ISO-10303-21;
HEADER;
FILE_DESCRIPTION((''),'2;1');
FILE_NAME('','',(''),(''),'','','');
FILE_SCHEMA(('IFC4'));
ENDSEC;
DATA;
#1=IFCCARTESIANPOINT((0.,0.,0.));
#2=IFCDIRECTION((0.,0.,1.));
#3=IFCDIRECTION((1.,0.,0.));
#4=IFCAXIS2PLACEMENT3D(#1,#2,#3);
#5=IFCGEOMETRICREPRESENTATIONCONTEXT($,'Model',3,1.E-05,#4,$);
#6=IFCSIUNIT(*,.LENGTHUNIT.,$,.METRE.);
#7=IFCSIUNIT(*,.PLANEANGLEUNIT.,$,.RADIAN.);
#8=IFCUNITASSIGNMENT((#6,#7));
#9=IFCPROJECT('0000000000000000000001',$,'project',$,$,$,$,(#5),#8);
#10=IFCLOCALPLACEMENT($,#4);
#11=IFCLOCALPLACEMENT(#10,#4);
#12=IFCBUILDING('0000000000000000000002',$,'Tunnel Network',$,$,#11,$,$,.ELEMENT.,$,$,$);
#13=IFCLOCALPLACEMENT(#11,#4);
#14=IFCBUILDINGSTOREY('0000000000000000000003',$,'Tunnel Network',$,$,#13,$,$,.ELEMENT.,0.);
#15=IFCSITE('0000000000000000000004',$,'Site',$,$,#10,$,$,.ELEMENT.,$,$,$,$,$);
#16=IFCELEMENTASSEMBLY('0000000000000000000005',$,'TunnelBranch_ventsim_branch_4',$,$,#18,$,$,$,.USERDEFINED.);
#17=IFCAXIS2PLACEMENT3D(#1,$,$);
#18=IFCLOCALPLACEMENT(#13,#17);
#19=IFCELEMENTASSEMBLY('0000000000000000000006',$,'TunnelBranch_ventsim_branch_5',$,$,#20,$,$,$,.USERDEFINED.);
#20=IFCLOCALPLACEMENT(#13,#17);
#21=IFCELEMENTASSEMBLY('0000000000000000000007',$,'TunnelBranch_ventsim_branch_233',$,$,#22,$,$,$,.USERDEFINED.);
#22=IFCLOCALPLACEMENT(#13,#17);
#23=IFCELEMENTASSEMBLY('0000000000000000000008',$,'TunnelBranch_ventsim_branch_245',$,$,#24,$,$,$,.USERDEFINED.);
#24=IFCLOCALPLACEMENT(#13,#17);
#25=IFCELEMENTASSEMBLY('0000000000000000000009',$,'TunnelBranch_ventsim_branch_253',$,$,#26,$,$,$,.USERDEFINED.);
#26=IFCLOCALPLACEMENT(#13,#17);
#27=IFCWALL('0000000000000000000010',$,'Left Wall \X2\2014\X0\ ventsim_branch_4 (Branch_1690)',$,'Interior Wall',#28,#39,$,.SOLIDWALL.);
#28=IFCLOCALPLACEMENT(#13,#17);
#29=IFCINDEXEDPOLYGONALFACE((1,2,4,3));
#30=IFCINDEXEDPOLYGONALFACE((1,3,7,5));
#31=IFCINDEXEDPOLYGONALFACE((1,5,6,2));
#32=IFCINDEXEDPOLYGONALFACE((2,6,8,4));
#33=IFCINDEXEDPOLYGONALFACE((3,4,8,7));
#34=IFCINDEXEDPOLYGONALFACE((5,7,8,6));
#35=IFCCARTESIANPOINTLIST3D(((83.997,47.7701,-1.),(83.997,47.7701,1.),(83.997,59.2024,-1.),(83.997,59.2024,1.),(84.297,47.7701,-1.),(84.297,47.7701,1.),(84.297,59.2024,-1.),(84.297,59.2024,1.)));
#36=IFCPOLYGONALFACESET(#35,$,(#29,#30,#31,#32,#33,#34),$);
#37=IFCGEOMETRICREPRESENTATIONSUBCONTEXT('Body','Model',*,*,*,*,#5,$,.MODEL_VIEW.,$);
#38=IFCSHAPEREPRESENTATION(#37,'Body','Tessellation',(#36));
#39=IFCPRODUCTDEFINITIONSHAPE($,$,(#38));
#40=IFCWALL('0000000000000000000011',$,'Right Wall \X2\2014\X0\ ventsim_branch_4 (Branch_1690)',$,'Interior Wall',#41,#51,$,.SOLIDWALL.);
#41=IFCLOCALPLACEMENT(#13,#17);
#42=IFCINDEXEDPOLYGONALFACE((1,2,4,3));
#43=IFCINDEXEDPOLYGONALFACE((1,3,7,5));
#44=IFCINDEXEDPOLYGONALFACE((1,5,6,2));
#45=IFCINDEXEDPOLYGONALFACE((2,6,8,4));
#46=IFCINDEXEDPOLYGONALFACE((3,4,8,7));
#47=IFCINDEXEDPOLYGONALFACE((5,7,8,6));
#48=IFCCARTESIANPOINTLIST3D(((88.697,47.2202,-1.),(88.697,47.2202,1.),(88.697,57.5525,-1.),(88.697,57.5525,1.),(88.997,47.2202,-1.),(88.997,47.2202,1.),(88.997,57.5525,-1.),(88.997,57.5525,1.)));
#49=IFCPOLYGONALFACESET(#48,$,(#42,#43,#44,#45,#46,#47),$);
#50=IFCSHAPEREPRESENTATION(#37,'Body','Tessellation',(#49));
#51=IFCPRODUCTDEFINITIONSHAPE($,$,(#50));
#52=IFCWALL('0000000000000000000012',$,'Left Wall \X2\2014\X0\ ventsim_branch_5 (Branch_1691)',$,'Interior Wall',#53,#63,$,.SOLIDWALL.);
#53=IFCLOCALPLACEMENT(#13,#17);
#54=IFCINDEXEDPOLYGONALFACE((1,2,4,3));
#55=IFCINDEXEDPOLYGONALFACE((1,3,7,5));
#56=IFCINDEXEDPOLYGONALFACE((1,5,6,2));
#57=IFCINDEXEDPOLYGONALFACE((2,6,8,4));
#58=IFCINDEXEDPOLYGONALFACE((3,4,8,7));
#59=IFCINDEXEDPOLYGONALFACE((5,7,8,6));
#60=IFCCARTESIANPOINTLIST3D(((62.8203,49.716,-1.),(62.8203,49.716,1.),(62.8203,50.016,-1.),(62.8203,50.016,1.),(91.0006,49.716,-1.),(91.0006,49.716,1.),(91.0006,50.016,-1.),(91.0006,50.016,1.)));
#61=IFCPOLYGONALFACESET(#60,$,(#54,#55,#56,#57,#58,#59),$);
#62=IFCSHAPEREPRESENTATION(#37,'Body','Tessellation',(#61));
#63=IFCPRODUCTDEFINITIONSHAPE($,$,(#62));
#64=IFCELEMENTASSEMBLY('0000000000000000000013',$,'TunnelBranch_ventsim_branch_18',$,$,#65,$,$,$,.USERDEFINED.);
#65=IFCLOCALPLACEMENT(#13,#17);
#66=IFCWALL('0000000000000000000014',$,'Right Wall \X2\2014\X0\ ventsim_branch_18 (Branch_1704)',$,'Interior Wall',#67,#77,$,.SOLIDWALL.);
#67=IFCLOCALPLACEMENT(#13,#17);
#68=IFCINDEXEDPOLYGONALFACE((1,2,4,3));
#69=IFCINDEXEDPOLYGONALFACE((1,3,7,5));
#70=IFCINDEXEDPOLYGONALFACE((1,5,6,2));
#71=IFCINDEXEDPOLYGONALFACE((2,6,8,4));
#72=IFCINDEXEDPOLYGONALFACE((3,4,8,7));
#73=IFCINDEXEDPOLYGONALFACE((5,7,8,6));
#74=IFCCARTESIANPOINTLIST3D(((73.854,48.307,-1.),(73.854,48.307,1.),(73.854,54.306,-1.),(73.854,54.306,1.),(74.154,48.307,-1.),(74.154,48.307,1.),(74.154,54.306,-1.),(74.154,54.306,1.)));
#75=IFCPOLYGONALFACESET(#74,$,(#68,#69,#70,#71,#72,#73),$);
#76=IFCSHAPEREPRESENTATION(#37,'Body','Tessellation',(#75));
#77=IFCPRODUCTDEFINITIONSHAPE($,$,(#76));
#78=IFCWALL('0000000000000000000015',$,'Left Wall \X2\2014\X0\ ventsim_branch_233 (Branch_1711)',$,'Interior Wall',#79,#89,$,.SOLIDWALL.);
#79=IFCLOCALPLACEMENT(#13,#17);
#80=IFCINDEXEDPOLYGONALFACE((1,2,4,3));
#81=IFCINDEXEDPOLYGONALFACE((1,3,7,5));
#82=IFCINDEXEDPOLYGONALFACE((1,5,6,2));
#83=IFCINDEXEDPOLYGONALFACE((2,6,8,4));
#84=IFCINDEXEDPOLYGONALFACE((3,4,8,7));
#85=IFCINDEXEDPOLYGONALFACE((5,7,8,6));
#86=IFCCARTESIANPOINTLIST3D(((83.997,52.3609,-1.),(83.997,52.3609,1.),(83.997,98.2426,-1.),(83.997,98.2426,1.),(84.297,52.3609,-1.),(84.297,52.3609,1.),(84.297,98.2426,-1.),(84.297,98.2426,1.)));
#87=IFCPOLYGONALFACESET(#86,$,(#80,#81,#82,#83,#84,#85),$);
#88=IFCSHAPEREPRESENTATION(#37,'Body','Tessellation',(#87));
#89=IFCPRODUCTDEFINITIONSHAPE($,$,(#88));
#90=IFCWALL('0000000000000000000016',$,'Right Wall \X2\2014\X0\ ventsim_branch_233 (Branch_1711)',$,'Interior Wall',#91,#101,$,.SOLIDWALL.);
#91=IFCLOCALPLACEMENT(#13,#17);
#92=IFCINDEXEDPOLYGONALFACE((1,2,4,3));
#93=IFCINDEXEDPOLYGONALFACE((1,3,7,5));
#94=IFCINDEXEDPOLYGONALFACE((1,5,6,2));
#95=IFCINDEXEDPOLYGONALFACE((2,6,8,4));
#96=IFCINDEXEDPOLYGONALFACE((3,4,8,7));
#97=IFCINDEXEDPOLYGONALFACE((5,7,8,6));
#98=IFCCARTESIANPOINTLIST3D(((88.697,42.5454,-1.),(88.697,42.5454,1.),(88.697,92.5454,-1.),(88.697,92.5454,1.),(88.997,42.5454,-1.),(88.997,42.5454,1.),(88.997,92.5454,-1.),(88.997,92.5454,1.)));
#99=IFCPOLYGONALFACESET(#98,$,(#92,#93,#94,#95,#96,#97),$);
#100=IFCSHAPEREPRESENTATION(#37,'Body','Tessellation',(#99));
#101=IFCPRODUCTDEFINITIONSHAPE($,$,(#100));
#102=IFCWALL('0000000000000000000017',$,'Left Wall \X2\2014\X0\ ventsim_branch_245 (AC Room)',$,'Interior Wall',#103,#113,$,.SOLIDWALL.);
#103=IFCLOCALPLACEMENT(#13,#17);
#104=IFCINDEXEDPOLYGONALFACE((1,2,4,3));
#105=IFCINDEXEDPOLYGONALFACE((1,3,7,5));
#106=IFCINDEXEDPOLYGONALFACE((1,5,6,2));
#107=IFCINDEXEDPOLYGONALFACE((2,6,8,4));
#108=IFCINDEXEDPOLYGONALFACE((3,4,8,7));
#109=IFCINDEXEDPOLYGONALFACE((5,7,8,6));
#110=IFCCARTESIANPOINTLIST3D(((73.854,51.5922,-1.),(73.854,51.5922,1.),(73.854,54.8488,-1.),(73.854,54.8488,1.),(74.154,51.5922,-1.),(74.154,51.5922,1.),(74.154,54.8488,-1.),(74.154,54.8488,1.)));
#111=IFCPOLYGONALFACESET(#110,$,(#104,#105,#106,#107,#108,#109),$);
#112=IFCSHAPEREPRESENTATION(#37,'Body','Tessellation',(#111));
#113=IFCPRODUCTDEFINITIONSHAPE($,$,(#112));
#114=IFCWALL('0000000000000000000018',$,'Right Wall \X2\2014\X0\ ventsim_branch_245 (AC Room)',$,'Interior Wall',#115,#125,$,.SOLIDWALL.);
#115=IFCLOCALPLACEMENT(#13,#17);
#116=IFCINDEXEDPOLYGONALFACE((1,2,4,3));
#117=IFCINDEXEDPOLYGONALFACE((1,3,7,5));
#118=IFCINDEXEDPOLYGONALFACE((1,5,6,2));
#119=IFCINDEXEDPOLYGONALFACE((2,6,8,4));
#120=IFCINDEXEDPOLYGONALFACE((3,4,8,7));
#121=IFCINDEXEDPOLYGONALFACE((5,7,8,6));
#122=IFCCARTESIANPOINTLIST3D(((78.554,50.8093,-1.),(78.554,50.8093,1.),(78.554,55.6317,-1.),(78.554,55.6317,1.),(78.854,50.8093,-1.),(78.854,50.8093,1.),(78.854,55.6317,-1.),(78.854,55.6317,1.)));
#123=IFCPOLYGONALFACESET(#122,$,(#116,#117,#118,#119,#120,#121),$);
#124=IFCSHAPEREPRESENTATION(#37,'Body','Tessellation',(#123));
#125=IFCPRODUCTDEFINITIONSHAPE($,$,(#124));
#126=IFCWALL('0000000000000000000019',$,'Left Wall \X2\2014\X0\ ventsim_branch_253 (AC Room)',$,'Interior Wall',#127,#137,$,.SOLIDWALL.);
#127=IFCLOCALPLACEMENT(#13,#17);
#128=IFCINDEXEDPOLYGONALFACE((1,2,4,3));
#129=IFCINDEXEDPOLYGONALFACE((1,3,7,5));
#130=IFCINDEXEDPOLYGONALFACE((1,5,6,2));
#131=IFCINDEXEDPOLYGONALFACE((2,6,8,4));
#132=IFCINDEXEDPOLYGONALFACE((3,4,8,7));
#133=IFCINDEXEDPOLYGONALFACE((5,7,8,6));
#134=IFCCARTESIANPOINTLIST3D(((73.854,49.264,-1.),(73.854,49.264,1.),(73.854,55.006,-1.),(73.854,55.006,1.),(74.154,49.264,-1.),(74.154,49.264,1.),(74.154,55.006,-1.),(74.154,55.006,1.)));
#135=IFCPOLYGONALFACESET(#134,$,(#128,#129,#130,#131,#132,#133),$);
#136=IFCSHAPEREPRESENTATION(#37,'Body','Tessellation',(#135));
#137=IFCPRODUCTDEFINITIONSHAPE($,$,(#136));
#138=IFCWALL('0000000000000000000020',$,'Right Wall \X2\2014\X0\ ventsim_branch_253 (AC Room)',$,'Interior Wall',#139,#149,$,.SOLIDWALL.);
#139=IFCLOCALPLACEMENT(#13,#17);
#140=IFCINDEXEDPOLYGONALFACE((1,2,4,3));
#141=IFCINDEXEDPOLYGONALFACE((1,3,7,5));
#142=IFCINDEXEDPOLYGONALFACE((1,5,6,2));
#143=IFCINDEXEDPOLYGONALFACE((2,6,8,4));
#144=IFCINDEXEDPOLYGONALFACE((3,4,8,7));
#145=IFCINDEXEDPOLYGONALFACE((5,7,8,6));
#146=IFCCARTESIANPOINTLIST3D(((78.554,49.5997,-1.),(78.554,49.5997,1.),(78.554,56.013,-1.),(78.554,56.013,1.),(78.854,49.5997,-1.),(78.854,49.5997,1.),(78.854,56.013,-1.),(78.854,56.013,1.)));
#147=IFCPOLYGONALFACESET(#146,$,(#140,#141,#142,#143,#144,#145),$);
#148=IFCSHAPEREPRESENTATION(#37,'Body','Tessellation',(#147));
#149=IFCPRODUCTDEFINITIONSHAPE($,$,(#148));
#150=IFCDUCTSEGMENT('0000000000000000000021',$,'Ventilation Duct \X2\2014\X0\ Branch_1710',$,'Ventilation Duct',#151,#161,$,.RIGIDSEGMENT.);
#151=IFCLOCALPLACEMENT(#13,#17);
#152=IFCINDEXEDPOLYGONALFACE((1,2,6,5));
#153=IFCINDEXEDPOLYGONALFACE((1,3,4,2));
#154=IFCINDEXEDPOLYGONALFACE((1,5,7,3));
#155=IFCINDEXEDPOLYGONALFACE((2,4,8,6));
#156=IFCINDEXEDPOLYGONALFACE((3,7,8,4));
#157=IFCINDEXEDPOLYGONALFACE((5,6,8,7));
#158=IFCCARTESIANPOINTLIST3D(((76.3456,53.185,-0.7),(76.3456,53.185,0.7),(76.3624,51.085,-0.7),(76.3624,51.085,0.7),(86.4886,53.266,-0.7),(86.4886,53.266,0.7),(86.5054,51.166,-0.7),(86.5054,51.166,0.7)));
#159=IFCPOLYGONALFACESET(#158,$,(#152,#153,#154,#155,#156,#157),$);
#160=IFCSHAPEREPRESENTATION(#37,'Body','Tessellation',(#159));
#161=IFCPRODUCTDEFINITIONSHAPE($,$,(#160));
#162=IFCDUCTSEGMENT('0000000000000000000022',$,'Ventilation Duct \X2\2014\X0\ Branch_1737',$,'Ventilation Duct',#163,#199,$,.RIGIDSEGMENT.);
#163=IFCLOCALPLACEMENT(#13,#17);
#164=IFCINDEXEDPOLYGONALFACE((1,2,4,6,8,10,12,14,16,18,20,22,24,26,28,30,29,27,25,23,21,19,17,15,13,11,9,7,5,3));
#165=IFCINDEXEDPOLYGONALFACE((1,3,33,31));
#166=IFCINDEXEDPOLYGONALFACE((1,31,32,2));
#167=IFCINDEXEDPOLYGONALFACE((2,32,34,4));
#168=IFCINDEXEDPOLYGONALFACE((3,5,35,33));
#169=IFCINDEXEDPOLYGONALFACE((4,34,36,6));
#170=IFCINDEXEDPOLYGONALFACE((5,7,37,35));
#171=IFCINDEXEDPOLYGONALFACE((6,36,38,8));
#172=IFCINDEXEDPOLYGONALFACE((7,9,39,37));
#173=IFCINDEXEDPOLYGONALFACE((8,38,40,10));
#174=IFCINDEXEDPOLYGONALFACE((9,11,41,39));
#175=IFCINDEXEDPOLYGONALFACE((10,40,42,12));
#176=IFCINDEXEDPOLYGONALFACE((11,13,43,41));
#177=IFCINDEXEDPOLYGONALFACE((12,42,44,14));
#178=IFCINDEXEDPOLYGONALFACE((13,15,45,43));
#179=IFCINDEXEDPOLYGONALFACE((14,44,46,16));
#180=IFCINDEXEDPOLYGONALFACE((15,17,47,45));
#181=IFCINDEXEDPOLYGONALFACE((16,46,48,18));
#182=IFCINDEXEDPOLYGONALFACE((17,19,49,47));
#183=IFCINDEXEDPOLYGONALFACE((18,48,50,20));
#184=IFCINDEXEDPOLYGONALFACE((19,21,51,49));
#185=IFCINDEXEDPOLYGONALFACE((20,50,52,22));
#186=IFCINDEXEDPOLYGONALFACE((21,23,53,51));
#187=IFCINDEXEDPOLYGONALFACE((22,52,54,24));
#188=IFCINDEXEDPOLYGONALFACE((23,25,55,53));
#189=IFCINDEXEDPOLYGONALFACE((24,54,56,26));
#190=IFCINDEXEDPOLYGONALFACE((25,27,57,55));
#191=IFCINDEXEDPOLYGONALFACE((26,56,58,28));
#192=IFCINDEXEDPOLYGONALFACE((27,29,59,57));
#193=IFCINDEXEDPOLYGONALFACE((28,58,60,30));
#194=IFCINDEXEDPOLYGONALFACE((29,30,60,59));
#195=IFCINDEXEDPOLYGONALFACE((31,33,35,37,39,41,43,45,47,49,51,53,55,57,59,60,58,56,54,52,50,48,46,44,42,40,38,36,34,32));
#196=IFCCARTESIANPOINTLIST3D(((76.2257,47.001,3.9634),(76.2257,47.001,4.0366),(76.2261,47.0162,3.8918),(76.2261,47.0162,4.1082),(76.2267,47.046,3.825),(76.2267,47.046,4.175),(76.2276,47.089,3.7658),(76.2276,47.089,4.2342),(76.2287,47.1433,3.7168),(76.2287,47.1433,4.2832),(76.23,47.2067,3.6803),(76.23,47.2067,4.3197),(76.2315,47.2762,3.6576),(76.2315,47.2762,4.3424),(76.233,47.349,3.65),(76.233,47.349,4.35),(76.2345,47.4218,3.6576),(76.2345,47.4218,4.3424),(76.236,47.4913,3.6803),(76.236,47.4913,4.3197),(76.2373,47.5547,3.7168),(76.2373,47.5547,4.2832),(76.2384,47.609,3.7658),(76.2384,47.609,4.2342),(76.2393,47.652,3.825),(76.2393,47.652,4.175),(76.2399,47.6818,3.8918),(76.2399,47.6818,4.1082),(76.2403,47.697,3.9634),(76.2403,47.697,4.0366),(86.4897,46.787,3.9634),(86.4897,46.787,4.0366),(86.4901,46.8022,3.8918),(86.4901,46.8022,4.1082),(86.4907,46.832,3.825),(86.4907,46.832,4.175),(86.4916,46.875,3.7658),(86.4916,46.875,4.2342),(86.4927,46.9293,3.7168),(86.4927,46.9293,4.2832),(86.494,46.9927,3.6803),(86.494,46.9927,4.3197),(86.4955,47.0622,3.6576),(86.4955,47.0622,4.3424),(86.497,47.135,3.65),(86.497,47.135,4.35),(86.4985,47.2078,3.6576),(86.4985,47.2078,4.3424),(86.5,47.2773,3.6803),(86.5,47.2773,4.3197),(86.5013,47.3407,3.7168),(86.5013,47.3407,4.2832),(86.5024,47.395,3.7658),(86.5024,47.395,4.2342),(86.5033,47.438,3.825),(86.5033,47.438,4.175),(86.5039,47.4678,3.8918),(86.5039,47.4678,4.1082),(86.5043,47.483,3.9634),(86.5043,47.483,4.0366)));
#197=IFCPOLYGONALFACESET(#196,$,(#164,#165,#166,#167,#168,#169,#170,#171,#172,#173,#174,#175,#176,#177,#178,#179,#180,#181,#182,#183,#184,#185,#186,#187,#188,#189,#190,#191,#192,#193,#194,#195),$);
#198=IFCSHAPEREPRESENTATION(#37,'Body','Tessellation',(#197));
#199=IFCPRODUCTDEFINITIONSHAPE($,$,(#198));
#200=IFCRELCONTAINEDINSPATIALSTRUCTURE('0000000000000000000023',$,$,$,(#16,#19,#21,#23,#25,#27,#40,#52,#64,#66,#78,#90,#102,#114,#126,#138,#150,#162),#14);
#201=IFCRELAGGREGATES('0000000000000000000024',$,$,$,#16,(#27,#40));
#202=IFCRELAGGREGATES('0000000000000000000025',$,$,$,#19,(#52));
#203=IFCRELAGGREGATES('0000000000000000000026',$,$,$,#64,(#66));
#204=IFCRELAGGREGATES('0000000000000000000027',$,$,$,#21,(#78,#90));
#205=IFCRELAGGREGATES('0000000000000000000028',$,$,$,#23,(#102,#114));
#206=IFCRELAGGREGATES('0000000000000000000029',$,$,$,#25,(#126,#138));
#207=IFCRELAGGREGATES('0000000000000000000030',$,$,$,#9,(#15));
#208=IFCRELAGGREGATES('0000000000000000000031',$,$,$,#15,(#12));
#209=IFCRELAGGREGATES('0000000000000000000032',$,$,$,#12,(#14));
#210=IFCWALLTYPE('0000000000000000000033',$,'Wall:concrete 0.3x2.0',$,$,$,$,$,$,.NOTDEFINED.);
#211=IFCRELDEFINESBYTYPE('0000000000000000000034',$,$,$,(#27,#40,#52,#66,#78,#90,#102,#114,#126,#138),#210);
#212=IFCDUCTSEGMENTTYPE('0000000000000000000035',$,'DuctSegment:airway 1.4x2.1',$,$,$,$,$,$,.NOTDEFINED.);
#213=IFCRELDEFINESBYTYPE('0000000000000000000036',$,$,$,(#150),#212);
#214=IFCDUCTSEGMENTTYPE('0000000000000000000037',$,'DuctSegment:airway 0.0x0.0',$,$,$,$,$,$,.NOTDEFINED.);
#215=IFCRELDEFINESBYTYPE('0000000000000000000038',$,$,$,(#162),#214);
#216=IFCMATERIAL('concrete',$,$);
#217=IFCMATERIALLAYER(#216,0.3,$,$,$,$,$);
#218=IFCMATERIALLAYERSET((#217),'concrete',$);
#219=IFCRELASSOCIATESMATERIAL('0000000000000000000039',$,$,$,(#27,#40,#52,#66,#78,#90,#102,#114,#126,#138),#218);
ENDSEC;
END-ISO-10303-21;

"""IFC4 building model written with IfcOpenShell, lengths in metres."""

from ifc_helpers import new_model, si_unit, frame, origin_with_axes, origin_2d_with_axis, place, context, subcontext, project, spatial, rectangle, circle, extrude, material, layer, layer_set, layer_usage, type_object, element, aggregate, save


model = new_model("IFC4")

# Units and contexts
model_context = context("Model", 3, precision=1e-05, world=origin_with_axes())
body_context = subcontext(model_context, "Body", "Model", "MODEL_VIEW")
ifc_project = project(units=[si_unit("LENGTHUNIT", "METRE"), si_unit("PLANEANGLEUNIT", "RADIAN")], contexts=[model_context])

# Site, building, storey
site_placement = place(None, origin_with_axes())
site = spatial("IfcSite", under=ifc_project, at=site_placement, Name="Site", CompositionType="ELEMENT")
building_placement = place(site_placement, origin_with_axes())
building = spatial("IfcBuilding", under=site, at=building_placement, Name="Tunnel Network", CompositionType="ELEMENT")
storey_placement = place(building_placement, origin_with_axes())
storey = spatial("IfcBuildingStorey", under=building, at=storey_placement, Name="Tunnel Network", CompositionType="ELEMENT", Elevation=0.0)

# Element assemblies
assembly_1_placement = place(storey_placement, frame((84.147, 47.7701, 0.0), z_axis=(0.0, 1.0, 0.0), x_axis=(1.0, 0.0, 0.0)))
assembly_1 = element("IfcElementAssembly", 1, at=assembly_1_placement, inside=storey, Name="TunnelBranch_ventsim_branch_4", PredefinedType="USERDEFINED")
ifc_material_1 = material(Name="concrete")
ifc_layer_1 = layer(ifc_material_1, 0.3)
ifc_layer_set_1 = layer_set([ifc_layer_1], Name="concrete")
assembly_2_placement = place(storey_placement, frame((91.0006, 49.866, 0.0), z_axis=(-1.0, 0.0, 0.0), x_axis=(0.0, 1.0, 0.0)))
assembly_2 = element("IfcElementAssembly", 2, at=assembly_2_placement, inside=storey, Name="TunnelBranch_ventsim_branch_5", PredefinedType="USERDEFINED")
assembly_3_placement = place(storey_placement, frame((84.147, 52.3609, 0.0), z_axis=(0.0, 1.0, 0.0), x_axis=(1.0, 0.0, 0.0)))
assembly_3 = element("IfcElementAssembly", 3, at=assembly_3_placement, inside=storey, Name="TunnelBranch_ventsim_branch_233", PredefinedType="USERDEFINED")
assembly_4_placement = place(storey_placement, frame((74.004, 51.5922, 0.0), z_axis=(0.0, 1.0, 0.0), x_axis=(1.0, 0.0, 0.0)))
assembly_4 = element("IfcElementAssembly", 4, at=assembly_4_placement, inside=storey, Name="TunnelBranch_ventsim_branch_245", PredefinedType="USERDEFINED")
assembly_5_placement = place(storey_placement, frame((74.004, 49.264, 0.0), z_axis=(0.0, 1.0, 0.0), x_axis=(1.0, 0.0, 0.0)))
assembly_5 = element("IfcElementAssembly", 5, at=assembly_5_placement, inside=storey, Name="TunnelBranch_ventsim_branch_253", PredefinedType="USERDEFINED")

# Walls
ifc_layer_usage_1 = layer_usage(ifc_layer_set_1, "AXIS2", "POSITIVE", 0.0)
wall_type_1 = type_object("IfcWallType", Name="Wall:concrete 0.3x2.0")
wall_1_placement = place(storey_placement, frame((84.147, 47.7701, 0.0), z_axis=(0.0, 1.0, 0.0), x_axis=(1.0, 0.0, 0.0)))
wall_1 = element("IfcWall", 6, at=wall_1_placement, inside=storey, type_object=wall_type_1, material=ifc_layer_usage_1, Name="Left Wall — ventsim_branch_4 (Branch_1690)", ObjectType="Interior Wall", PredefinedType="SOLIDWALL", context=body_context, shape_type="SweptSolid", body=[
    extrude(rectangle(XDim=0.3, YDim=2.0, at=origin_2d_with_axis()), origin_with_axes(), (0.0, 0.0, 1.0), 11.4323),
])
ifc_layer_usage_2 = layer_usage(ifc_layer_set_1, "AXIS2", "POSITIVE", 0.0)
wall_2_placement = place(storey_placement, frame((88.847, 47.2202, 0.0), z_axis=(0.0, 1.0, 0.0), x_axis=(1.0, 0.0, 0.0)))
wall_2 = element("IfcWall", 7, at=wall_2_placement, inside=storey, type_object=wall_type_1, material=ifc_layer_usage_2, Name="Right Wall — ventsim_branch_4 (Branch_1690)", ObjectType="Interior Wall", PredefinedType="SOLIDWALL", context=body_context, shape_type="SweptSolid", body=[
    extrude(rectangle(XDim=0.3, YDim=2.0, at=origin_2d_with_axis()), origin_with_axes(), (0.0, 0.0, 1.0), 10.3323),
])
aggregate(assembly_1, [wall_1, wall_2])
ifc_layer_usage_3 = layer_usage(ifc_layer_set_1, "AXIS2", "POSITIVE", 0.0)
wall_3_placement = place(storey_placement, frame((91.0006, 49.866, 0.0), z_axis=(-1.0, 0.0, 0.0), x_axis=(0.0, 1.0, 0.0)))
wall_3 = element("IfcWall", 8, at=wall_3_placement, inside=storey, type_object=wall_type_1, material=ifc_layer_usage_3, Name="Left Wall — ventsim_branch_5 (Branch_1691)", ObjectType="Interior Wall", PredefinedType="SOLIDWALL", context=body_context, shape_type="SweptSolid", body=[
    extrude(rectangle(XDim=0.3, YDim=2.0, at=origin_2d_with_axis()), origin_with_axes(), (0.0, 0.0, 1.0), 28.1803),
])
aggregate(assembly_2, [wall_3])

# Element assembly, wall
assembly_6_placement = place(storey_placement, frame((78.704, 54.306, 0.0), z_axis=(0.0, -1.0, 0.0), x_axis=(-1.0, 0.0, 0.0)))
assembly_6 = element("IfcElementAssembly", 9, at=assembly_6_placement, inside=storey, Name="TunnelBranch_ventsim_branch_18", PredefinedType="USERDEFINED")
ifc_layer_usage_4 = layer_usage(ifc_layer_set_1, "AXIS2", "POSITIVE", 0.0)
wall_4_placement = place(storey_placement, frame((74.004, 54.306, 0.0), z_axis=(0.0, -1.0, 0.0), x_axis=(-1.0, 0.0, 0.0)))
wall_4 = element("IfcWall", 10, at=wall_4_placement, inside=storey, type_object=wall_type_1, material=ifc_layer_usage_4, Name="Right Wall — ventsim_branch_18 (Branch_1704)", ObjectType="Interior Wall", PredefinedType="SOLIDWALL", context=body_context, shape_type="SweptSolid", body=[
    extrude(rectangle(XDim=0.3, YDim=2.0, at=origin_2d_with_axis()), origin_with_axes(), (0.0, 0.0, 1.0), 5.999),
])
aggregate(assembly_6, [wall_4])

# Walls
ifc_layer_usage_5 = layer_usage(ifc_layer_set_1, "AXIS2", "POSITIVE", 0.0)
wall_5_placement = place(storey_placement, frame((84.147, 52.3609, 0.0), z_axis=(0.0, 1.0, 0.0), x_axis=(1.0, 0.0, 0.0)))
wall_5 = element("IfcWall", 11, at=wall_5_placement, inside=storey, type_object=wall_type_1, material=ifc_layer_usage_5, Name="Left Wall — ventsim_branch_233 (Branch_1711)", ObjectType="Interior Wall", PredefinedType="SOLIDWALL", context=body_context, shape_type="SweptSolid", body=[
    extrude(rectangle(XDim=0.3, YDim=2.0, at=origin_2d_with_axis()), origin_with_axes(), (0.0, 0.0, 1.0), 45.8817),
])
ifc_layer_usage_6 = layer_usage(ifc_layer_set_1, "AXIS2", "POSITIVE", 0.0)
wall_6_placement = place(storey_placement, frame((88.847, 42.5454, 0.0), z_axis=(0.0, 1.0, 0.0), x_axis=(1.0, 0.0, 0.0)))
wall_6 = element("IfcWall", 12, at=wall_6_placement, inside=storey, type_object=wall_type_1, material=ifc_layer_usage_6, Name="Right Wall — ventsim_branch_233 (Branch_1711)", ObjectType="Interior Wall", PredefinedType="SOLIDWALL", context=body_context, shape_type="SweptSolid", body=[
    extrude(rectangle(XDim=0.3, YDim=2.0, at=origin_2d_with_axis()), origin_with_axes(), (0.0, 0.0, 1.0), 50.0),
])
aggregate(assembly_3, [wall_5, wall_6])
ifc_layer_usage_7 = layer_usage(ifc_layer_set_1, "AXIS2", "POSITIVE", 0.0)
wall_7_placement = place(storey_placement, frame((74.004, 51.5922, 0.0), z_axis=(0.0, 1.0, 0.0), x_axis=(1.0, 0.0, 0.0)))
wall_7 = element("IfcWall", 13, at=wall_7_placement, inside=storey, type_object=wall_type_1, material=ifc_layer_usage_7, Name="Left Wall — ventsim_branch_245 (AC Room)", ObjectType="Interior Wall", PredefinedType="SOLIDWALL", context=body_context, shape_type="SweptSolid", body=[
    extrude(rectangle(XDim=0.3, YDim=2.0, at=origin_2d_with_axis()), origin_with_axes(), (0.0, 0.0, 1.0), 3.2565),
])
ifc_layer_usage_8 = layer_usage(ifc_layer_set_1, "AXIS2", "POSITIVE", 0.0)
wall_8_placement = place(storey_placement, frame((78.704, 50.8093, 0.0), z_axis=(0.0, 1.0, 0.0), x_axis=(1.0, 0.0, 0.0)))
wall_8 = element("IfcWall", 14, at=wall_8_placement, inside=storey, type_object=wall_type_1, material=ifc_layer_usage_8, Name="Right Wall — ventsim_branch_245 (AC Room)", ObjectType="Interior Wall", PredefinedType="SOLIDWALL", context=body_context, shape_type="SweptSolid", body=[
    extrude(rectangle(XDim=0.3, YDim=2.0, at=origin_2d_with_axis()), origin_with_axes(), (0.0, 0.0, 1.0), 4.8224),
])
aggregate(assembly_4, [wall_7, wall_8])
ifc_layer_usage_9 = layer_usage(ifc_layer_set_1, "AXIS2", "POSITIVE", 0.0)
wall_9_placement = place(storey_placement, frame((74.004, 49.264, 0.0), z_axis=(0.0, 1.0, 0.0), x_axis=(1.0, 0.0, 0.0)))
wall_9 = element("IfcWall", 15, at=wall_9_placement, inside=storey, type_object=wall_type_1, material=ifc_layer_usage_9, Name="Left Wall — ventsim_branch_253 (AC Room)", ObjectType="Interior Wall", PredefinedType="SOLIDWALL", context=body_context, shape_type="SweptSolid", body=[
    extrude(rectangle(XDim=0.3, YDim=2.0, at=origin_2d_with_axis()), origin_with_axes(), (0.0, 0.0, 1.0), 5.742),
])
ifc_layer_usage_10 = layer_usage(ifc_layer_set_1, "AXIS2", "POSITIVE", 0.0)
wall_10_placement = place(storey_placement, frame((78.704, 49.5997, 0.0), z_axis=(0.0, 1.0, 0.0), x_axis=(1.0, 0.0, 0.0)))
wall_10 = element("IfcWall", 16, at=wall_10_placement, inside=storey, type_object=wall_type_1, material=ifc_layer_usage_10, Name="Right Wall — ventsim_branch_253 (AC Room)", ObjectType="Interior Wall", PredefinedType="SOLIDWALL", context=body_context, shape_type="SweptSolid", body=[
    extrude(rectangle(XDim=0.3, YDim=2.0, at=origin_2d_with_axis()), origin_with_axes(), (0.0, 0.0, 1.0), 6.4133),
])
aggregate(assembly_5, [wall_9, wall_10])

# Duct segments
duct_segment_type_1 = type_object("IfcDuctSegmentType", Name="DuctSegment:airway 1.4x2.1")
duct_segment_1_placement = place(storey_placement, frame((76.354, 52.135, 0.0), z_axis=(0.999968, 0.007986, 0.0), x_axis=(0.0, 0.0, 1.0)))
element("IfcDuctSegment", 17, at=duct_segment_1_placement, inside=storey, type_object=duct_segment_type_1, Name="Ventilation Duct — Branch_1710", ObjectType="Ventilation Duct", PredefinedType="RIGIDSEGMENT", context=body_context, shape_type="SweptSolid", body=[
    extrude(rectangle(XDim=1.4, YDim=2.1, at=origin_2d_with_axis()), origin_with_axes(), (0.0, 0.0, 1.0), 10.1433),
])
duct_segment_type_2 = type_object("IfcDuctSegmentType", Name="DuctSegment:airway 0.0x0.0")
duct_segment_2_placement = place(storey_placement, frame((86.497, 47.135, 4.0), z_axis=(-0.999783, 0.020845, 0.0), x_axis=(0.0, 0.0, 1.0)))
element("IfcDuctSegment", 18, at=duct_segment_2_placement, inside=storey, type_object=duct_segment_type_2, Name="Ventilation Duct — Branch_1737", ObjectType="Ventilation Duct", PredefinedType="RIGIDSEGMENT", context=body_context, shape_type="SweptSolid", body=[
    extrude(circle(Radius=0.35, at=origin_2d_with_axis()), origin_with_axes(), (0.0, 0.0, 1.0), 10.2662),
])

save(model, "model.ifc")
